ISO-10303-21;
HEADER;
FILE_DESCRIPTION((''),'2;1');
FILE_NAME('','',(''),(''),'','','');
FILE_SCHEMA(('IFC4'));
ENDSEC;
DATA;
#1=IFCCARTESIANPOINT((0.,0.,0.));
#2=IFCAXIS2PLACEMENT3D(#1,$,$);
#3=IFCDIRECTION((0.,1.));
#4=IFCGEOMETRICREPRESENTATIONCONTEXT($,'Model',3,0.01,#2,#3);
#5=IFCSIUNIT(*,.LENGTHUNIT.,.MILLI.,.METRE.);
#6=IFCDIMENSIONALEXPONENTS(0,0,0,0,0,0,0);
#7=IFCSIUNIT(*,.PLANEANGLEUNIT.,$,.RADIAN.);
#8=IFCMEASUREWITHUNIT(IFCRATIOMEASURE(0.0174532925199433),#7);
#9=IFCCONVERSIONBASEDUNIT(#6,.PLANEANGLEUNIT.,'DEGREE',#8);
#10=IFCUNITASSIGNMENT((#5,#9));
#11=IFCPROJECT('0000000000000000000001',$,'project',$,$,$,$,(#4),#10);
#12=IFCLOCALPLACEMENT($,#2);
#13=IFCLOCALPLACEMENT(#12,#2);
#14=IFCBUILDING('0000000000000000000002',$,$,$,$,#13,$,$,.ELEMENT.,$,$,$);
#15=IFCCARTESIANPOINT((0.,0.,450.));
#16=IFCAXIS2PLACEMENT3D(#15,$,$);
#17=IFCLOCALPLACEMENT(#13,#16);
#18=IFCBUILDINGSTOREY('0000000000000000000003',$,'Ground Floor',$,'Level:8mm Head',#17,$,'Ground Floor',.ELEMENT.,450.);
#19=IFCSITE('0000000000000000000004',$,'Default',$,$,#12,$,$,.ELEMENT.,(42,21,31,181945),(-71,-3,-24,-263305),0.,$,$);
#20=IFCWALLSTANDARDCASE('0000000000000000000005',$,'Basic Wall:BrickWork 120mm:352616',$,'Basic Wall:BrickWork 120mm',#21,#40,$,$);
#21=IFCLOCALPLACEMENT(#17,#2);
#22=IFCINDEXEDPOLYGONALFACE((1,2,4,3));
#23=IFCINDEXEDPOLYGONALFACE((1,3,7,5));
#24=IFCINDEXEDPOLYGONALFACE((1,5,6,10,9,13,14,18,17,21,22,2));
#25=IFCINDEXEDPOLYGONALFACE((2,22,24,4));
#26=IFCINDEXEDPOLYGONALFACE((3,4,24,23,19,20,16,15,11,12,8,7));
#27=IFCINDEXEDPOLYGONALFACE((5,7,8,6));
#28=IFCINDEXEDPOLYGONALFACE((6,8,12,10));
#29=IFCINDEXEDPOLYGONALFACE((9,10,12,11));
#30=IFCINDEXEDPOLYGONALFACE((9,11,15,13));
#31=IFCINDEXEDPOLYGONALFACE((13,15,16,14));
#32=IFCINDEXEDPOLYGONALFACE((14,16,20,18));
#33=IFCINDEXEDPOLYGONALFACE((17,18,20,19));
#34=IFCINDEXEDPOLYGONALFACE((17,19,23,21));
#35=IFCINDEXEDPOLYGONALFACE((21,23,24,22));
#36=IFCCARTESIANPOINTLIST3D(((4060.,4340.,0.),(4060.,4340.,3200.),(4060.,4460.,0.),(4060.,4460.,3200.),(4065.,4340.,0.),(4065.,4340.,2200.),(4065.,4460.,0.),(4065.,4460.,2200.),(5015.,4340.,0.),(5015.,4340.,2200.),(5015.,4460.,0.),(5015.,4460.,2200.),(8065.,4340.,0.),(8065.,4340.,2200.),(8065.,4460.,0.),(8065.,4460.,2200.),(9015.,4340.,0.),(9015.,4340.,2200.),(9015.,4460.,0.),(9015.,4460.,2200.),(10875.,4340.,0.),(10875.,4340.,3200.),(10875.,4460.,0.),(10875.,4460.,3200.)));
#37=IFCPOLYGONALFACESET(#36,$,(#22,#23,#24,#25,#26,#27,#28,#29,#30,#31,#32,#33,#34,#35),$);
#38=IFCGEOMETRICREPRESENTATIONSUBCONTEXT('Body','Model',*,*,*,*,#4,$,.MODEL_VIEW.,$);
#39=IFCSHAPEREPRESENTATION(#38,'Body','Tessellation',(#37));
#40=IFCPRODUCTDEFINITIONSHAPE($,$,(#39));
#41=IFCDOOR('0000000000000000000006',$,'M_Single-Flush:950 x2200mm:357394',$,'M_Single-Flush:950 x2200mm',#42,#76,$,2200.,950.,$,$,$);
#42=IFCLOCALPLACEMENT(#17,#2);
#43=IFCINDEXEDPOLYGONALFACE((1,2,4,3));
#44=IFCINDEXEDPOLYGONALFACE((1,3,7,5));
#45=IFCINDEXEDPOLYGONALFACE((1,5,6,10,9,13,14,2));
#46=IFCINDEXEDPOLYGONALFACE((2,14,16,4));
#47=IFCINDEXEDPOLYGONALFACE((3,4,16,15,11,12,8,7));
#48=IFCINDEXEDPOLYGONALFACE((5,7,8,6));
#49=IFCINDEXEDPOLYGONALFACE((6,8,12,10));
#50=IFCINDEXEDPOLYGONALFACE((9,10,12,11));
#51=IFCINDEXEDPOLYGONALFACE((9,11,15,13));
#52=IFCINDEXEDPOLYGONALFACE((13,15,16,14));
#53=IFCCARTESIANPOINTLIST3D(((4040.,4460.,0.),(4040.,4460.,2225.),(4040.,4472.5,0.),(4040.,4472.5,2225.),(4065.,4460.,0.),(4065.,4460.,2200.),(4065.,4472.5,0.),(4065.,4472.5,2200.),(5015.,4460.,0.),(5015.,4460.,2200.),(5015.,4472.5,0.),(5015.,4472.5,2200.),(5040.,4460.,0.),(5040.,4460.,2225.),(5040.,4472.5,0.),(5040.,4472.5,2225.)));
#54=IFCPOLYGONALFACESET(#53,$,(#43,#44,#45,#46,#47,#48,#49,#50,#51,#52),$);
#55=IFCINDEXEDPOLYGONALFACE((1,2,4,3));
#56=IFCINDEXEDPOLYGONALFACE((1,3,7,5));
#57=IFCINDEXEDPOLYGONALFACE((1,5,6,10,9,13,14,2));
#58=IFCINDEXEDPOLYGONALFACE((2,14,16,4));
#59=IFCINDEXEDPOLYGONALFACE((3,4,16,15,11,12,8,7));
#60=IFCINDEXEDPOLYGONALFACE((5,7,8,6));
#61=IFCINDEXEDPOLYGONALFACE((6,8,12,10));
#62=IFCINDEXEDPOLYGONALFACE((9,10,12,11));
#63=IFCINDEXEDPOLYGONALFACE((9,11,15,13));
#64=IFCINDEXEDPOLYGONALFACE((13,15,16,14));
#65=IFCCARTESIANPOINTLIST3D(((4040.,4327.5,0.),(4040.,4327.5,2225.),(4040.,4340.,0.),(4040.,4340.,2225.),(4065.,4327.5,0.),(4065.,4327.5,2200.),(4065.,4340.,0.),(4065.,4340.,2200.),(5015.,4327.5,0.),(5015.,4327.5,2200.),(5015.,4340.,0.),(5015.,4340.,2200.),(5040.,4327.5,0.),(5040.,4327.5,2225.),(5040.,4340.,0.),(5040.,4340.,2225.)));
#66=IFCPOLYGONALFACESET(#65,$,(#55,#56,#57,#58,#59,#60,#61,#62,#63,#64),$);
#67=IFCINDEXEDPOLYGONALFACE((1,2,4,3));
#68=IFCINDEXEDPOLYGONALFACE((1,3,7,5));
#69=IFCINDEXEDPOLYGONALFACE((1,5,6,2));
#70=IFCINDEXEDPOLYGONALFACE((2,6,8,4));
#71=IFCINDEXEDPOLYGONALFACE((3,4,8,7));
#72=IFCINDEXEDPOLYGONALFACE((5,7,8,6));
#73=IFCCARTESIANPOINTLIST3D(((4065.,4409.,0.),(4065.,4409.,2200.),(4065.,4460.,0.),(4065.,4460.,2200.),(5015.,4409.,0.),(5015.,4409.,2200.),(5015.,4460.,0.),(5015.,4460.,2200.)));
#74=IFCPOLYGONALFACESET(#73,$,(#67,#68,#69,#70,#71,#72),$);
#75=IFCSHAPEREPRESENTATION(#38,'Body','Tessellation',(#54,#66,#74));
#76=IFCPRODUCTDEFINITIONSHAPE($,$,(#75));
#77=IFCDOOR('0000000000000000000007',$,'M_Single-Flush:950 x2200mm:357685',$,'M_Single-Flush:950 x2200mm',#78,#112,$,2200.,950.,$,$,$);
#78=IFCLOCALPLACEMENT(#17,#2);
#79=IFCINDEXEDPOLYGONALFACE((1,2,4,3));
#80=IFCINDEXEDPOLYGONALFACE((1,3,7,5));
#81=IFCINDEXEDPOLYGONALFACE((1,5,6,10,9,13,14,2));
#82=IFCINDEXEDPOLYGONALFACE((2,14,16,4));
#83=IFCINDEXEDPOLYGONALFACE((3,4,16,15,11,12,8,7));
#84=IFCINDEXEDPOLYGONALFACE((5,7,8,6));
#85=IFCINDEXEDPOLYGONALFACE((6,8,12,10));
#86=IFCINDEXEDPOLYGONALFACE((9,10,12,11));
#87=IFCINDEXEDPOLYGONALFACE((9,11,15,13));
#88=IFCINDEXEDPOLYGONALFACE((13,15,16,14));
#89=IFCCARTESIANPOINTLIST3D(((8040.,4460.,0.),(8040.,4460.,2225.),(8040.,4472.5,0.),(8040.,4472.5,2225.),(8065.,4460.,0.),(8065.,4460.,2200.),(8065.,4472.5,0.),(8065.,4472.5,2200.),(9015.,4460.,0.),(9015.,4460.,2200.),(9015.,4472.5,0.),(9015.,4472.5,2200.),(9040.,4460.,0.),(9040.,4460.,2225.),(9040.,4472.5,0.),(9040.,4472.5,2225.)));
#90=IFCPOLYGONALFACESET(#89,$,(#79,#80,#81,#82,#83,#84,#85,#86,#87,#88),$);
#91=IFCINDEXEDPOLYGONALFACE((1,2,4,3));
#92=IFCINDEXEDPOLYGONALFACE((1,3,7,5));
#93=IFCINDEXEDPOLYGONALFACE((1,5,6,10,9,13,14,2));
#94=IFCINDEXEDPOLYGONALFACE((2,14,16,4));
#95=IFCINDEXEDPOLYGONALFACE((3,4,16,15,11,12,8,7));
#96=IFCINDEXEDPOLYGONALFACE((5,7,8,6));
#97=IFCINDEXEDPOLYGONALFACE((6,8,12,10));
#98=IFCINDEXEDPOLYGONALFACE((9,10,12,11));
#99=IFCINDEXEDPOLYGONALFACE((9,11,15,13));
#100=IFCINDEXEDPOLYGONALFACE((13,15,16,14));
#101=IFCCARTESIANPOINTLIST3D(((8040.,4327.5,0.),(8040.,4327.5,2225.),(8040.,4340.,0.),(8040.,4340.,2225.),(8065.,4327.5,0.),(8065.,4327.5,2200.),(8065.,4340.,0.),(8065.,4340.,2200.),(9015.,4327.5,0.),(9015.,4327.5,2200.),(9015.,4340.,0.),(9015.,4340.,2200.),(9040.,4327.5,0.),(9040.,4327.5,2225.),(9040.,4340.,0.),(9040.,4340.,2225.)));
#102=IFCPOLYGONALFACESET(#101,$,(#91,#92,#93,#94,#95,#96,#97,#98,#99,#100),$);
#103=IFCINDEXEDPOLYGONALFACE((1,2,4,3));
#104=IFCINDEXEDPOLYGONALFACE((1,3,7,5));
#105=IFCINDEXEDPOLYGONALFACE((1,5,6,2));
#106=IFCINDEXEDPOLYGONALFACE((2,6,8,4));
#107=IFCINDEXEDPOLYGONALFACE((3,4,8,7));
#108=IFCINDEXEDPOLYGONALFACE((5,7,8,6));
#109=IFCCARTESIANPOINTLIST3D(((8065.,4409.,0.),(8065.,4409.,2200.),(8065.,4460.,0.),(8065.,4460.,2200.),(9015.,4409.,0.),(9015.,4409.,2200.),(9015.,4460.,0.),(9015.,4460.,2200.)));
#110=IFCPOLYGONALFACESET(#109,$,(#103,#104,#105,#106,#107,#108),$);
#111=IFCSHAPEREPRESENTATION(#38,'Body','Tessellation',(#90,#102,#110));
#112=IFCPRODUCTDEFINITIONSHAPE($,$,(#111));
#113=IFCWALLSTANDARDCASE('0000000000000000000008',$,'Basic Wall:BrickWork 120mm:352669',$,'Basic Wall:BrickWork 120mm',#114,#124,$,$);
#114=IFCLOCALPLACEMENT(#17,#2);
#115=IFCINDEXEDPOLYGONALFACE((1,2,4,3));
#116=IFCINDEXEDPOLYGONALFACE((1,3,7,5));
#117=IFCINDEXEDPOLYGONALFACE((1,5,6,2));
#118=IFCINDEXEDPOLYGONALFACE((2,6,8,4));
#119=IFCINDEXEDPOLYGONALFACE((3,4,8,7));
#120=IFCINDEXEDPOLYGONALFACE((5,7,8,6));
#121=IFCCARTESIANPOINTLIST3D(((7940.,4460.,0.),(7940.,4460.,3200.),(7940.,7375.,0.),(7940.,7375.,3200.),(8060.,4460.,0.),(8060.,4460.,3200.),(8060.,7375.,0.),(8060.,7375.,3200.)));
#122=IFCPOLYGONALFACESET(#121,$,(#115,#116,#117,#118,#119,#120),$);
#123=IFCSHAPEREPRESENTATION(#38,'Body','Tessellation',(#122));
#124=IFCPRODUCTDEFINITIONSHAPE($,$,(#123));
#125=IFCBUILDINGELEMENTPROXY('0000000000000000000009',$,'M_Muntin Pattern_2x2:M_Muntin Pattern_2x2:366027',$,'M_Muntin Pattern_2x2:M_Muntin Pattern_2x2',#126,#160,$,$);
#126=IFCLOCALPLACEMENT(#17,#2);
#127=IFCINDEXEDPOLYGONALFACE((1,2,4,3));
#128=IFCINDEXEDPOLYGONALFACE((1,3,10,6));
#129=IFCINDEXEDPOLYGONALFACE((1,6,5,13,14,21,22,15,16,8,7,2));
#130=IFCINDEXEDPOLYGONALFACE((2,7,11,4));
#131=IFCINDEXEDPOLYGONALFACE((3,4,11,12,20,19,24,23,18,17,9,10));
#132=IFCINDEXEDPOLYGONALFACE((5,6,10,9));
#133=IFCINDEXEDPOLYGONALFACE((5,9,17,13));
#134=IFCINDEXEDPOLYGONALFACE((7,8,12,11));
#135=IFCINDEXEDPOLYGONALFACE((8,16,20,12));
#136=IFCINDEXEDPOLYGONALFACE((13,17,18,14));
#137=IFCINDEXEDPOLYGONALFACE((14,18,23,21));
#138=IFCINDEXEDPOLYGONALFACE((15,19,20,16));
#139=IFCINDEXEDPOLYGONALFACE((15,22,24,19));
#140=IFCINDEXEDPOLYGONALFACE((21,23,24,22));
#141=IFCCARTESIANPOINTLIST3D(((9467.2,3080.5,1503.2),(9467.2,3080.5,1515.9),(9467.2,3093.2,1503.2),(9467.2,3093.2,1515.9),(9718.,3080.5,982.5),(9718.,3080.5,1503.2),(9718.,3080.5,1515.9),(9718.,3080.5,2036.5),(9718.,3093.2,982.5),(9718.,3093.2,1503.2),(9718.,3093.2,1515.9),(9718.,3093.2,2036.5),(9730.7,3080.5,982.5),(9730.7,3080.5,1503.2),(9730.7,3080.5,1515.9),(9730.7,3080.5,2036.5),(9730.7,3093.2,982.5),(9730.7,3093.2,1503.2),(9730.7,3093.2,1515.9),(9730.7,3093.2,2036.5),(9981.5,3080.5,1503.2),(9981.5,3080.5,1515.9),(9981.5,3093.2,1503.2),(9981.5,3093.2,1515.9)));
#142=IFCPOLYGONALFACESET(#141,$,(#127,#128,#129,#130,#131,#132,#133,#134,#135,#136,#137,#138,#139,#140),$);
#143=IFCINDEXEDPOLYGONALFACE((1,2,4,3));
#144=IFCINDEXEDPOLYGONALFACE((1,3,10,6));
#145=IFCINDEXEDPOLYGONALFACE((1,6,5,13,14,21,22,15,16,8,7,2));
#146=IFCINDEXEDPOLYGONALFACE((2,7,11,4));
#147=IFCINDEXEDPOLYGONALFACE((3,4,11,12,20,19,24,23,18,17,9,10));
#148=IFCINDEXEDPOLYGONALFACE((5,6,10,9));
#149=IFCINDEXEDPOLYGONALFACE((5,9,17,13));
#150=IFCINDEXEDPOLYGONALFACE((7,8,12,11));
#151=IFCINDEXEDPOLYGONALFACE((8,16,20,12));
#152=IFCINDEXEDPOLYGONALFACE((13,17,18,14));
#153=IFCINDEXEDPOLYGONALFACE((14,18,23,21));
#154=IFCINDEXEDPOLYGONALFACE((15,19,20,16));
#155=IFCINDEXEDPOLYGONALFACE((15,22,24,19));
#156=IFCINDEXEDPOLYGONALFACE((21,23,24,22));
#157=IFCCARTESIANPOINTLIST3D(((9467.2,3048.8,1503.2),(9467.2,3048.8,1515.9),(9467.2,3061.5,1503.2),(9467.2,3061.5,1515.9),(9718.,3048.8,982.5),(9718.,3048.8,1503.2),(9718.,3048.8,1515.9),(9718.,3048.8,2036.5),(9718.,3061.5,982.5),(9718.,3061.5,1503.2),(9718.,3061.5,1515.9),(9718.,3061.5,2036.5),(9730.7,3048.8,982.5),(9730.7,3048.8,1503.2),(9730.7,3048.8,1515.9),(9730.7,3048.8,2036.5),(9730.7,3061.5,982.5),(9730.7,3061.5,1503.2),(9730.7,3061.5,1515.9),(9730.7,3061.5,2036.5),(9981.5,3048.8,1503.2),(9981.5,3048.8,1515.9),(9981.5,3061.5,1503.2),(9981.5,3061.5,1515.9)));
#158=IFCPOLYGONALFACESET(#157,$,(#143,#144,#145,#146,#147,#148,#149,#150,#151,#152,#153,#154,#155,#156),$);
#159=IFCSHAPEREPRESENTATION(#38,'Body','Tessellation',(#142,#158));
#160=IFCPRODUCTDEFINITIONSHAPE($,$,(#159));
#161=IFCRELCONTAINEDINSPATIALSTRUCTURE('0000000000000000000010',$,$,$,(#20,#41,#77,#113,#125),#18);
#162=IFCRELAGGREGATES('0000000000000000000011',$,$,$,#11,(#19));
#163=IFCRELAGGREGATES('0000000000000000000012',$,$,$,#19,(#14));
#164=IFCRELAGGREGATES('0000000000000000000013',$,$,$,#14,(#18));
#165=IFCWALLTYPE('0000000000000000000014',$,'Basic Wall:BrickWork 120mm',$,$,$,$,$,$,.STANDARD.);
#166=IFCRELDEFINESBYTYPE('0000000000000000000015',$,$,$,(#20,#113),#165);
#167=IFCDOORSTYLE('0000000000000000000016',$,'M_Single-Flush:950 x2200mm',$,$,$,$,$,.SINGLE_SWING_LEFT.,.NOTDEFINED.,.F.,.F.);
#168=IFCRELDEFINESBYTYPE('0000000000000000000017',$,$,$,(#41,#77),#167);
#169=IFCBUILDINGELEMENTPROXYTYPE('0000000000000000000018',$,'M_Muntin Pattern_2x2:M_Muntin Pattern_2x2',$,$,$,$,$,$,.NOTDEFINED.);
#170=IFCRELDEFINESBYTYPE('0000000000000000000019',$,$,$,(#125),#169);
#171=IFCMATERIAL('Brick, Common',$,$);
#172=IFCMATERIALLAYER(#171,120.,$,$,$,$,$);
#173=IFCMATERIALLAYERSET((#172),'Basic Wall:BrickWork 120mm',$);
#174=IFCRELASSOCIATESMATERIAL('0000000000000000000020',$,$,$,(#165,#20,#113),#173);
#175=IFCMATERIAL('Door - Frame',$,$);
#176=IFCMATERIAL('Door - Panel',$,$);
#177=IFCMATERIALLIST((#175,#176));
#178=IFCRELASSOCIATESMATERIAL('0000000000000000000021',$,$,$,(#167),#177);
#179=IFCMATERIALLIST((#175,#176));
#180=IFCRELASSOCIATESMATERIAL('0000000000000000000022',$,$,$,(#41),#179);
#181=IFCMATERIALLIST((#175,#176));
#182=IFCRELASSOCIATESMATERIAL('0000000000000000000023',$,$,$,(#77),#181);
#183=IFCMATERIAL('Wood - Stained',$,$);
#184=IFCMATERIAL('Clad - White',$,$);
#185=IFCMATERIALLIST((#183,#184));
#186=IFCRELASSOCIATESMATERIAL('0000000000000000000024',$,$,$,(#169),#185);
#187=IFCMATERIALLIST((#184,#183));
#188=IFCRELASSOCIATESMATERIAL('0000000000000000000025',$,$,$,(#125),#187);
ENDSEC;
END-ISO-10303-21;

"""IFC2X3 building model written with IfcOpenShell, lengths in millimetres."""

from ifc_helpers import new_model, entity, si_unit, converted_unit, direction, frame, frame_2d, origin, place, context, subcontext, project, spatial, polyline, rectangle, outline, extrude, source, transform, mapped, material, material_list, layer, layer_set, layer_usage, type_object, type_shapes, element, fill, save


model = new_model("IFC2X3")

# Units and contexts
model_context = context("Model", 3, precision=0.01, world=origin(), true_north=direction((0.0, 1.0)))
body_context = subcontext(model_context, "Body", "Model", "MODEL_VIEW")
ifc_project = project(units=[si_unit("LENGTHUNIT", "METRE", prefix="MILLI"), converted_unit("PLANEANGLEUNIT", "DEGREE", entity("IfcRatioMeasure", 0.0174532925199433), si_unit("PLANEANGLEUNIT", "RADIAN"), dimensions=[0, 0, 0, 0, 0, 0, 0])], contexts=[model_context])

# Site, building, storey
site_placement = place(None, origin())
site = spatial("IfcSite", under=ifc_project, at=site_placement, Name="Default", CompositionType="ELEMENT", RefLatitude=(42, 21, 31, 181945), RefLongitude=(-71, -3, -24, -263305), RefElevation=0.0)
building_placement = place(site_placement, origin())
building = spatial("IfcBuilding", under=site, at=building_placement, CompositionType="ELEMENT")
storey_placement = place(building_placement, frame((0.0, 0.0, 450.0)))
storey = spatial("IfcBuildingStorey", under=building, at=storey_placement, Name="Ground Floor", ObjectType="Level:8mm Head", LongName="Ground Floor", CompositionType="ELEMENT", Elevation=450.0)

# Shared definitions
ifc_material_1 = material(Name="Brick, Common")

# Wall, openings, doors
ifc_layer_1 = layer(ifc_material_1, 120.0)
ifc_layer_set_1 = layer_set([ifc_layer_1], Name="Basic Wall:BrickWork 120mm")
ifc_layer_usage_1 = layer_usage(ifc_layer_set_1, "AXIS2", "NEGATIVE", 60.0)
wall_type_1 = type_object("IfcWallType", Name="Basic Wall:BrickWork 120mm", PredefinedType="STANDARD", material=ifc_layer_set_1)
wall_1_placement = place(storey_placement, frame((10875.0, 4400.0, 0.0), z_axis=(0.0, 0.0, 1.0), x_axis=(-1.0, 0.0, 0.0)))
wall_1 = element("IfcWallStandardCase", 1, at=wall_1_placement, inside=storey, type_object=wall_type_1, material=ifc_layer_usage_1, Name="Basic Wall:BrickWork 120mm:352616", ObjectType="Basic Wall:BrickWork 120mm", context=body_context, shape_type="SweptSolid", body=[
    extrude(rectangle(XDim=6815.0, YDim=120.0, at=frame_2d((3407.5, 0.0), x_axis=(-1.0, 0.0))), origin(), (0.0, 0.0, 1.0), 3200.0),
])
opening_1_placement = place(wall_1_placement, frame((6810.0, 60.0, 0.0)))
opening_1 = element("IfcOpeningElement", 2, at=opening_1_placement, cuts=wall_1, ObjectType="Opening", context=body_context, shape_type="SweptSolid", body=[
    extrude(rectangle(XDim=950.0, YDim=2200.0, at=frame_2d((1100.0, 475.0), x_axis=(0.0, -1.0))), frame((0.0, 0.0, 0.0), z_axis=(0.0, -1.0, 0.0), x_axis=(0.0, 0.0, 1.0)), (0.0, 0.0, 1.0), 120.0),
])
opening_2_placement = place(wall_1_placement, frame((2810.0, 60.0, 0.0)))
opening_2 = element("IfcOpeningElement", 3, at=opening_2_placement, cuts=wall_1, ObjectType="Opening", context=body_context, shape_type="SweptSolid", body=[
    extrude(rectangle(XDim=950.0, YDim=2200.0, at=frame_2d((1100.0, 475.0), x_axis=(0.0, -1.0))), frame((0.0, 0.0, 0.0), z_axis=(0.0, -1.0, 0.0), x_axis=(0.0, 0.0, 1.0)), (0.0, 0.0, 1.0), 120.0),
])
ifc_material_2 = material(Name="Door - Frame")
ifc_material_3 = material(Name="Door - Panel")
ifc_material_list_1 = material_list([ifc_material_2, ifc_material_3])
ifc_material_list_2 = material_list([ifc_material_2, ifc_material_3])
door_style_1 = type_object("IfcDoorStyle", Name="M_Single-Flush:950 x2200mm", ConstructionType="NOTDEFINED", OperationType="SINGLE_SWING_LEFT", ParameterTakesPrecedence=False, Sizeable=False, material=ifc_material_list_2)
shared_shape_1 = source(origin(), body_context, "Body", "SweptSolid", [
    extrude(outline(polyline([(-500.0, -1118.8), (500.0, -1118.8), (500.0, 1106.2), (475.0, 1106.2), (475.0, -1093.8), (-475.0, -1093.8), (-475.0, 1106.2), (-500.0, 1106.2), (-500.0, -1118.8)])), frame((475.0, 132.5, 1106.2), z_axis=(0.0, -1.0, 0.0), x_axis=(-1.0, 0.0, 0.0)), (0.0, 0.0, 1.0), 12.5),
    extrude(outline(polyline([(-1118.8, -500.0), (1106.2, -500.0), (1106.2, -475.0), (-1093.8, -475.0), (-1093.8, 475.0), (1106.2, 475.0), (1106.2, 500.0), (-1118.8, 500.0), (-1118.8, -500.0)])), frame((475.0, 0.0, 1106.2), z_axis=(0.0, -1.0, 0.0), x_axis=(0.0, 0.0, -1.0)), (0.0, 0.0, 1.0), 12.5),
    extrude(rectangle(XDim=950.0, YDim=51.0, at=frame_2d((0.0, 0.0), x_axis=(1.0, 0.0))), frame((475.0, 94.5, 0.0)), (0.0, 0.0, 1.0), 2200.0),
])
type_shapes(door_style_1, [shared_shape_1])
door_1_placement = place(opening_1_placement, frame((0.0, 0.0, 0.0), z_axis=(0.0, 0.0, 1.0), x_axis=(-1.0, 0.0, 0.0)))
door_1 = element("IfcDoor", 4, at=door_1_placement, inside=storey, type_object=door_style_1, material=ifc_material_list_1, Name="M_Single-Flush:950 x2200mm:357394", ObjectType="M_Single-Flush:950 x2200mm", OverallHeight=2200.0, OverallWidth=950.0, context=body_context, shape_type="MappedRepresentation", body=[
    mapped(shared_shape_1, transform((0.0, 0.0, 0.0), scale=1.0)),
])
fill(opening_1, door_1)
ifc_material_list_3 = material_list([ifc_material_2, ifc_material_3])
door_2_placement = place(opening_2_placement, frame((0.0, 0.0, 0.0), z_axis=(0.0, 0.0, 1.0), x_axis=(-1.0, 0.0, 0.0)))
door_2 = element("IfcDoor", 5, at=door_2_placement, inside=storey, type_object=door_style_1, material=ifc_material_list_3, Name="M_Single-Flush:950 x2200mm:357685", ObjectType="M_Single-Flush:950 x2200mm", OverallHeight=2200.0, OverallWidth=950.0, context=body_context, shape_type="MappedRepresentation", body=[
    mapped(shared_shape_1, transform((0.0, 0.0, 0.0), scale=1.0)),
])
fill(opening_2, door_2)

# Wall
ifc_layer_usage_2 = layer_usage(ifc_layer_set_1, "AXIS2", "NEGATIVE", 60.0)
wall_2_placement = place(storey_placement, frame((8000.0, 7375.0, 0.0), z_axis=(0.0, 0.0, 1.0), x_axis=(0.0, -1.0, 0.0)))
element("IfcWallStandardCase", 6, at=wall_2_placement, inside=storey, type_object=wall_type_1, material=ifc_layer_usage_2, Name="Basic Wall:BrickWork 120mm:352669", ObjectType="Basic Wall:BrickWork 120mm", context=body_context, shape_type="SweptSolid", body=[
    extrude(rectangle(XDim=2915.0, YDim=120.0, at=frame_2d((1457.5, 0.0), x_axis=(-1.0, 0.0))), origin(), (0.0, 0.0, 1.0), 3200.0),
])

# Building element proxy
ifc_material_4 = material(Name="Clad - White")
ifc_material_5 = material(Name="Wood - Stained")
ifc_material_list_4 = material_list([ifc_material_4, ifc_material_5])
ifc_material_list_5 = material_list([ifc_material_5, ifc_material_4])
building_element_proxy_type_1 = type_object("IfcBuildingElementProxyType", Name="M_Muntin Pattern_2x2:M_Muntin Pattern_2x2", PredefinedType="NOTDEFINED", material=ifc_material_list_5)
shared_shape_2 = source(origin(), body_context, "Body", "SweptSolid", [
    extrude(outline(polyline([(6.4, -6.4), (527.0, -6.4), (527.0, 6.3), (6.4, 6.3), (6.4, 257.1), (-6.3, 257.1), (-6.3, 6.3), (-527.0, 6.3), (-527.0, -6.4), (-6.3, -6.4), (-6.3, -257.1), (6.4, -257.1), (6.4, -6.4)])), frame((0.0, 9.5, 527.0), z_axis=(0.0, 1.0, 0.0), x_axis=(0.0, 0.0, 1.0)), (0.0, 0.0, 1.0), 12.7),
    extrude(outline(polyline([(6.4, -6.4), (527.0, -6.4), (527.0, 6.3), (6.4, 6.3), (6.4, 257.1), (-6.3, 257.1), (-6.3, 6.3), (-527.0, 6.3), (-527.0, -6.4), (-6.3, -6.4), (-6.3, -257.1), (6.4, -257.1), (6.4, -6.4)])), frame((0.0, -22.2, 527.0), z_axis=(0.0, 1.0, 0.0), x_axis=(0.0, 0.0, 1.0)), (0.0, 0.0, 1.0), 12.7),
])
type_shapes(building_element_proxy_type_1, [shared_shape_2])
proxy_1_placement = place(storey_placement, frame((9724.4, 3071.0, 982.5)))
element("IfcBuildingElementProxy", 7, at=proxy_1_placement, inside=storey, type_object=building_element_proxy_type_1, material=ifc_material_list_4, Name="M_Muntin Pattern_2x2:M_Muntin Pattern_2x2:366027", ObjectType="M_Muntin Pattern_2x2:M_Muntin Pattern_2x2", context=body_context, shape_type="MappedRepresentation", body=[
    mapped(shared_shape_2, transform((0.0, 0.0, 0.0), scale=1.0)),
])

save(model, "model.ifc")
